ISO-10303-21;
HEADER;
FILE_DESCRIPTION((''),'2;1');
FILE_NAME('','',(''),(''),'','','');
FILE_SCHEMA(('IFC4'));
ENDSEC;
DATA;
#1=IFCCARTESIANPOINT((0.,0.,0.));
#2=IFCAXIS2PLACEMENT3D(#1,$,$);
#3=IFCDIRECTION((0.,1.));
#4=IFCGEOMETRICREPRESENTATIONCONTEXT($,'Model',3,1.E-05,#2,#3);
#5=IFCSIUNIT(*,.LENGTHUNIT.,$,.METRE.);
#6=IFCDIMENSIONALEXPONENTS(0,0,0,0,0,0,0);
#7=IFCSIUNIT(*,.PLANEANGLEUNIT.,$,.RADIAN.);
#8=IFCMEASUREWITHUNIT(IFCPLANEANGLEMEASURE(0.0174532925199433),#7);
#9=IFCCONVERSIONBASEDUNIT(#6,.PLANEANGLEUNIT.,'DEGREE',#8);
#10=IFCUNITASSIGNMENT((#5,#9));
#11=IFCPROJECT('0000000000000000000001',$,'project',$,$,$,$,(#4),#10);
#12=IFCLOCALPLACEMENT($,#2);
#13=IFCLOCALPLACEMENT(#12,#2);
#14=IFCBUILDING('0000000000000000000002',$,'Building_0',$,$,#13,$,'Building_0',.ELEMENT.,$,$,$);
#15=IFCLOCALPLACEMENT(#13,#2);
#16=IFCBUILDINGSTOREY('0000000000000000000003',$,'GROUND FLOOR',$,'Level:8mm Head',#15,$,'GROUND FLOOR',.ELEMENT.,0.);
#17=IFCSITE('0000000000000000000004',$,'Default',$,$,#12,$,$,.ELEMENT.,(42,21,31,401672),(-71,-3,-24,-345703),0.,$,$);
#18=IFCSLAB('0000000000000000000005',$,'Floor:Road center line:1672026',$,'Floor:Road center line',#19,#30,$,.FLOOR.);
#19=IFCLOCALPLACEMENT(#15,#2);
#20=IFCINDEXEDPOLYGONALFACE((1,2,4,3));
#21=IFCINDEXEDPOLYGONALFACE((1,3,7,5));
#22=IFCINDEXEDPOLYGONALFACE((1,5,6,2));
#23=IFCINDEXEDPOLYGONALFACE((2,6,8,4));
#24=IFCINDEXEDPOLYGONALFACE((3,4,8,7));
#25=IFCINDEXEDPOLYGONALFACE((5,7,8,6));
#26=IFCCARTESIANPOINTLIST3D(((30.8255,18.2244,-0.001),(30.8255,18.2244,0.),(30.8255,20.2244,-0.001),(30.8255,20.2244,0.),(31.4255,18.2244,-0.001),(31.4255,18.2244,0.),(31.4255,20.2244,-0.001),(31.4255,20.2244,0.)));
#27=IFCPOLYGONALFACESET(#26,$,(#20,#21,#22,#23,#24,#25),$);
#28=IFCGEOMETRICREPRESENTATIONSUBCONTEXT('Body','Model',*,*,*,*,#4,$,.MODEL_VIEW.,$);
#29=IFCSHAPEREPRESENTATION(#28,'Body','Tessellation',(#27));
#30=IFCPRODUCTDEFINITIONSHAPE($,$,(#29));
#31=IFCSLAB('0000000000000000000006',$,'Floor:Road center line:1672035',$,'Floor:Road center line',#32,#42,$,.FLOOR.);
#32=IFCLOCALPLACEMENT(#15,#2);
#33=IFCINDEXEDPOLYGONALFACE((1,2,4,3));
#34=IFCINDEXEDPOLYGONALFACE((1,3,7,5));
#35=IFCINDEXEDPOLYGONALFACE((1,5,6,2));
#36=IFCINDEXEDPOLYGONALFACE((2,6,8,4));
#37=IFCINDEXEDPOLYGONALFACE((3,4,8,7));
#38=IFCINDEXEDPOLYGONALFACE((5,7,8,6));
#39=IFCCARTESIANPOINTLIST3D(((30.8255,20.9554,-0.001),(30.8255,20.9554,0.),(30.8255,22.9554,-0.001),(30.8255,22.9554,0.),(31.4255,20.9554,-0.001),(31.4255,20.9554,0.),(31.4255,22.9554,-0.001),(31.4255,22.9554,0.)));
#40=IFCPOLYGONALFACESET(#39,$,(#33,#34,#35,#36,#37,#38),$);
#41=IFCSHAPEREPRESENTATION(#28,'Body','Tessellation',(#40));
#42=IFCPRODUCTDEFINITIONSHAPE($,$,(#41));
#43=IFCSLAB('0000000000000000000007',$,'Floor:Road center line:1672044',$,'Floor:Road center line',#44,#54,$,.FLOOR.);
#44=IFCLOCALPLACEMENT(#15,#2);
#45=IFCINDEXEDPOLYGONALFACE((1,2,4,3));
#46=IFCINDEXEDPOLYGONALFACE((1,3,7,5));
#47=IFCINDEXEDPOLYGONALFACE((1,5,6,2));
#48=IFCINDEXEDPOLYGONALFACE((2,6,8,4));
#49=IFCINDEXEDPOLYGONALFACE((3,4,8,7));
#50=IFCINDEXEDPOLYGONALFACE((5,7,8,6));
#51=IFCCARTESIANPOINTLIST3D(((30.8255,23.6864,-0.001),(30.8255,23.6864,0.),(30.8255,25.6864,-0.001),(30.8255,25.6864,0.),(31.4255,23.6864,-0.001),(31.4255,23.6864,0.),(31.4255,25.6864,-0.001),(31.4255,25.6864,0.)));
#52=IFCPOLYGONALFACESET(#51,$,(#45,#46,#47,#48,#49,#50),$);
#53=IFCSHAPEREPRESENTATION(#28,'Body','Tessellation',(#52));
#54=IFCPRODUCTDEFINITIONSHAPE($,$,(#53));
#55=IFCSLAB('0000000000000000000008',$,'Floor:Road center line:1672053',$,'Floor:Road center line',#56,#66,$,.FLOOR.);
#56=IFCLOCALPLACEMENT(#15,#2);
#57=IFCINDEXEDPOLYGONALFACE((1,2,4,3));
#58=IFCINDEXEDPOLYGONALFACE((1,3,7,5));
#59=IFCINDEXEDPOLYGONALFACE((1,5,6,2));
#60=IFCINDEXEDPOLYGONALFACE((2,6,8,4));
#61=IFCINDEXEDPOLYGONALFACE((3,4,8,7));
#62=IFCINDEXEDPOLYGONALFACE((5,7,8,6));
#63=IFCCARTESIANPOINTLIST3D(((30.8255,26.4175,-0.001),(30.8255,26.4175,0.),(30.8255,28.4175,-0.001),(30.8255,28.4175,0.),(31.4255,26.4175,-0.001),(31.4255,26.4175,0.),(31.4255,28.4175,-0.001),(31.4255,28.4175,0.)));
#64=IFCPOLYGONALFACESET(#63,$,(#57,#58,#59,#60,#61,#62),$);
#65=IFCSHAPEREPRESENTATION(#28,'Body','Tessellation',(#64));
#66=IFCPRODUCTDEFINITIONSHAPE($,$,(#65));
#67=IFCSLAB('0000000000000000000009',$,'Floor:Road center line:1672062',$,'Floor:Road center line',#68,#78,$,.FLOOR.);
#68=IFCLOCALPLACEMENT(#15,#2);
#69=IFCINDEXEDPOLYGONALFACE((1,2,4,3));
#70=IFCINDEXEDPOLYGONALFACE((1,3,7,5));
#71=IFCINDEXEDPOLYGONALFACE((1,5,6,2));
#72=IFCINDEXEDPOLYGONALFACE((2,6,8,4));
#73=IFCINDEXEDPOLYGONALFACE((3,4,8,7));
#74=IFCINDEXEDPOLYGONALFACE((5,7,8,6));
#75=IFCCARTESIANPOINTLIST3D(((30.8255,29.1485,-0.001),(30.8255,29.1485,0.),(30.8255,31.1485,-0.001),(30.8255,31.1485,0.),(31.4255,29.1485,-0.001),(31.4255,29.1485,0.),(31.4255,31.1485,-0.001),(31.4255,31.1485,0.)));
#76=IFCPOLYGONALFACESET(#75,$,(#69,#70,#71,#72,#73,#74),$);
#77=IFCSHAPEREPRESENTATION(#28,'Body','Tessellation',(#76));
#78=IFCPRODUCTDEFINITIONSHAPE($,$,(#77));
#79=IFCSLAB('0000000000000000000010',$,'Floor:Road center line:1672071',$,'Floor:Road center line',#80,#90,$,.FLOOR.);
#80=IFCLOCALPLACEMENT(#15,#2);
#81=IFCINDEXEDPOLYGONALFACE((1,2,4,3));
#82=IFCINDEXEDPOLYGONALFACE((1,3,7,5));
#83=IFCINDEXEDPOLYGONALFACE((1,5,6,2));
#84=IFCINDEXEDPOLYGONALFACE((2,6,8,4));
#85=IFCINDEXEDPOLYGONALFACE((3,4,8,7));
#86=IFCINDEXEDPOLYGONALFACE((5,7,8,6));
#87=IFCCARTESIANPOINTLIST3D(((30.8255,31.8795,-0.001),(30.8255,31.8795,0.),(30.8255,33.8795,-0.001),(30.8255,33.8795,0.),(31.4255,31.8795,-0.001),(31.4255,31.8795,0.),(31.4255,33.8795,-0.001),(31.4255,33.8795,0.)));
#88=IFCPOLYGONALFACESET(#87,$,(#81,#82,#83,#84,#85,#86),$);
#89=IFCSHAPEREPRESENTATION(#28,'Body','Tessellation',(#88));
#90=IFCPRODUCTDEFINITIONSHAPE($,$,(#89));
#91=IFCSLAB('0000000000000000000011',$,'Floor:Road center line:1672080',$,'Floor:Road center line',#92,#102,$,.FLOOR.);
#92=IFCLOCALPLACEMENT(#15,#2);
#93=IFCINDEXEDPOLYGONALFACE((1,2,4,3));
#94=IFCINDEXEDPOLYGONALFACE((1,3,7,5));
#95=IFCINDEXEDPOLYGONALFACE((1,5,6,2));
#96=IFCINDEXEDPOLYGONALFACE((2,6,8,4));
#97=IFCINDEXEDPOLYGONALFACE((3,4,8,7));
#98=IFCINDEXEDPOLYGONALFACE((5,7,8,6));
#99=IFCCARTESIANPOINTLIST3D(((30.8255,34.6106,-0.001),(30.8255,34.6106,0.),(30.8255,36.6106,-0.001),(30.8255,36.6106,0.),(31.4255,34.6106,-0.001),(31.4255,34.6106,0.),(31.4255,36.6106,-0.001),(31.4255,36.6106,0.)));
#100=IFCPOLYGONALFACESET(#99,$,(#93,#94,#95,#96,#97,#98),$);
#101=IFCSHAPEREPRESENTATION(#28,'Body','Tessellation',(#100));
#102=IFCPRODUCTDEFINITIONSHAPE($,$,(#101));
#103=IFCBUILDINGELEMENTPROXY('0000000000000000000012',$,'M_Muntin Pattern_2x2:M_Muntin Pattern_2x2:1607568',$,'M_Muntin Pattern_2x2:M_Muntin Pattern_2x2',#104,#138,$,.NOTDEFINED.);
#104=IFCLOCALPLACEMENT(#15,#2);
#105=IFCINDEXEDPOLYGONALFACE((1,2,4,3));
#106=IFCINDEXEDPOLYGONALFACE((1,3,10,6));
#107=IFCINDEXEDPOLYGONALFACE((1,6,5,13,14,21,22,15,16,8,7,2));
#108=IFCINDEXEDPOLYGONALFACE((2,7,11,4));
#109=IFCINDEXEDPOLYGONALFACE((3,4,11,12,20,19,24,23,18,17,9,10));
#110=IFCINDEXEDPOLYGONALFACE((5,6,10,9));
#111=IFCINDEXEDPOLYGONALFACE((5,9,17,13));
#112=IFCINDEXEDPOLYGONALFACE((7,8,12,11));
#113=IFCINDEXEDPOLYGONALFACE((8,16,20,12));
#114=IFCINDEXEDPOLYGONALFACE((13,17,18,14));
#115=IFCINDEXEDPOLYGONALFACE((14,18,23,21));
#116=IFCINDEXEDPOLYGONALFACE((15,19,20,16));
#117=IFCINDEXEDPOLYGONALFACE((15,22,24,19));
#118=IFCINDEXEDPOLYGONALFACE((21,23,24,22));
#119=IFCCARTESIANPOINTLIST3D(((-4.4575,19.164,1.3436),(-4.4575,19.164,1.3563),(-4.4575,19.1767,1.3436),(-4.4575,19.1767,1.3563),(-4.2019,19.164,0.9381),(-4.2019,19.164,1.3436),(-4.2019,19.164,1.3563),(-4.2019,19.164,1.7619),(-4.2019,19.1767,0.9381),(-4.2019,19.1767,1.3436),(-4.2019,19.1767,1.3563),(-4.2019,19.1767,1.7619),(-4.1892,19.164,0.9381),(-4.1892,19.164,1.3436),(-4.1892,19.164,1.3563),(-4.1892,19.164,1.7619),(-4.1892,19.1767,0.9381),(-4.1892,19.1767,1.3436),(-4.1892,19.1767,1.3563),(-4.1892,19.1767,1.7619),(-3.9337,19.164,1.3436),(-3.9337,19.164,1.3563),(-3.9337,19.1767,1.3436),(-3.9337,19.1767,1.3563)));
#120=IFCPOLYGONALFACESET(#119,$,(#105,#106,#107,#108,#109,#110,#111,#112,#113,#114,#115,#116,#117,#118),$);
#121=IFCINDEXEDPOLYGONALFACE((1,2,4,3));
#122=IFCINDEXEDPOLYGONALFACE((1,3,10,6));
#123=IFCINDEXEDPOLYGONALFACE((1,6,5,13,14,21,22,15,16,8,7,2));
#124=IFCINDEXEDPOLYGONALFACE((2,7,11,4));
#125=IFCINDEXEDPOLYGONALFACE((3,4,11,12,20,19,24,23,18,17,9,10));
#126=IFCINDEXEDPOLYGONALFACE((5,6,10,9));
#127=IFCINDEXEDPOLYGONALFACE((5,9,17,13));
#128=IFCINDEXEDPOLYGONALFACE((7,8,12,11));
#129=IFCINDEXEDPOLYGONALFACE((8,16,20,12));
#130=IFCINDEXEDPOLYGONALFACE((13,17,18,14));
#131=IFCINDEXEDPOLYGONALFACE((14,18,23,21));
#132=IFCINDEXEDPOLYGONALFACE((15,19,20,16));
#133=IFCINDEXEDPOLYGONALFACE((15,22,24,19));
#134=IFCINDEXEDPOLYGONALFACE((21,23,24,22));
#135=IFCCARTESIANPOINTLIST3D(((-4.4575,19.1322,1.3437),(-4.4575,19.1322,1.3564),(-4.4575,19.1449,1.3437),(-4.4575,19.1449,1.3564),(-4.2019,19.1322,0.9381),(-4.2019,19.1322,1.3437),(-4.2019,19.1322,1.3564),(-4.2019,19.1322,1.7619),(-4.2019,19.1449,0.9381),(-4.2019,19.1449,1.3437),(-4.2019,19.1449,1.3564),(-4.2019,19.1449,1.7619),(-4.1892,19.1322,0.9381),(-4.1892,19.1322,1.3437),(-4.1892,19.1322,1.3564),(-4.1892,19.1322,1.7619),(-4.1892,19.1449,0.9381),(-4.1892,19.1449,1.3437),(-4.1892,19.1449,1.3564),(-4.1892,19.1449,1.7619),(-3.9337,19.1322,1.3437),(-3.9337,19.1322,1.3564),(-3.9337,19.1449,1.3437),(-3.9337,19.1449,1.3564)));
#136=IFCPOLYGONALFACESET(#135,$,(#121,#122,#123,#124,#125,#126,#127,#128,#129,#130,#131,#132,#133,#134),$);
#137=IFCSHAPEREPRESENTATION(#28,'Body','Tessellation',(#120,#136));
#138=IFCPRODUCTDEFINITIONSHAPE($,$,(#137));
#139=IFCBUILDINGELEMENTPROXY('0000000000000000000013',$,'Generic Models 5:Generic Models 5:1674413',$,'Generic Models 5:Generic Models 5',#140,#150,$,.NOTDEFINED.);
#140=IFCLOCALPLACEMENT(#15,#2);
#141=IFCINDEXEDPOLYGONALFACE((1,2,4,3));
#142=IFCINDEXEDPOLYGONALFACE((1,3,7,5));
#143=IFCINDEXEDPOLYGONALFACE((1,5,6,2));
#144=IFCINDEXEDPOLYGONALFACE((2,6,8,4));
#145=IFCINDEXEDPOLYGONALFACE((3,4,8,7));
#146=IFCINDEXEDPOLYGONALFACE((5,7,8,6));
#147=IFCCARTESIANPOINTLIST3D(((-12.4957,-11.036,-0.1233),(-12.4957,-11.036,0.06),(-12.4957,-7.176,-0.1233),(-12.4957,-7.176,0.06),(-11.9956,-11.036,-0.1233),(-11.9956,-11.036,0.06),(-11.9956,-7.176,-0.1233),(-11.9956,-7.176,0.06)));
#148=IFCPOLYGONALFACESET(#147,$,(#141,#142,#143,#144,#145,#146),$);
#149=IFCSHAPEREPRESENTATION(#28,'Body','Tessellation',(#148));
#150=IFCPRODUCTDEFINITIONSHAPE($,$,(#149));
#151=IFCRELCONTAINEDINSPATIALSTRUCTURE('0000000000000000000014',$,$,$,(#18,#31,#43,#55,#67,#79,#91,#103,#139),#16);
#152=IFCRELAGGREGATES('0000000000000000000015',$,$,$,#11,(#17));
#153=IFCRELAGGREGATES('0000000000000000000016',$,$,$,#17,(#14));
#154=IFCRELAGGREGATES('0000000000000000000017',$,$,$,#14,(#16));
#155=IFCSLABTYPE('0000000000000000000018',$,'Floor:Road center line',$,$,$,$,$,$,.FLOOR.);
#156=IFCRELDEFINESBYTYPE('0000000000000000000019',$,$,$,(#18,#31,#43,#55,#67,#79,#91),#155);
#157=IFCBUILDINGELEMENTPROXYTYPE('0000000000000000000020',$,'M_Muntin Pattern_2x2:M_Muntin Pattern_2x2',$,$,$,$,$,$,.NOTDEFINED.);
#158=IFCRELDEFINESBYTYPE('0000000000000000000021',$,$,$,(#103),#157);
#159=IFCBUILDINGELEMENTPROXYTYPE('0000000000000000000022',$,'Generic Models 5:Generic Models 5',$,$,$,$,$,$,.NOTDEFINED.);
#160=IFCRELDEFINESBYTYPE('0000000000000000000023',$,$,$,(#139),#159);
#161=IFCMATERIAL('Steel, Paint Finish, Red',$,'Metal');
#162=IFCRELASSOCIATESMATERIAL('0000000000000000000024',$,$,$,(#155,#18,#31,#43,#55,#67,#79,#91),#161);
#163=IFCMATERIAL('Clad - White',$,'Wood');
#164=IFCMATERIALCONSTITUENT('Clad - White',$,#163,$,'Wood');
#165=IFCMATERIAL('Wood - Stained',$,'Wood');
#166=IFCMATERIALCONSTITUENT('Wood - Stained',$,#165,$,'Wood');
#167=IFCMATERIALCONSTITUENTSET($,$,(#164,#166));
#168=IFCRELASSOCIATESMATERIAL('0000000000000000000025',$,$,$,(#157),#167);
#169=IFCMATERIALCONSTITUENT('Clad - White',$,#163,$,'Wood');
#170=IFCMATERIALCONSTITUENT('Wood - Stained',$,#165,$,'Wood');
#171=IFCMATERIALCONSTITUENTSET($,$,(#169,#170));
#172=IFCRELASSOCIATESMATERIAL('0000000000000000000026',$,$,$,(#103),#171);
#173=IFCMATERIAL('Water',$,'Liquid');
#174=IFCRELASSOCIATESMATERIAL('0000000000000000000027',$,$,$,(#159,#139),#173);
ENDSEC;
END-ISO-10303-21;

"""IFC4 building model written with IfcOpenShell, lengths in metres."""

from ifc_helpers import new_model, entity, si_unit, converted_unit, direction, frame, origin, place, context, subcontext, project, spatial, indexed_curve, outline, extrude, source, transform, mapped, material, constituent, constituent_set, type_object, type_shapes, element, save


model = new_model("IFC4")

# Units and contexts
model_context = context("Model", 3, precision=1e-05, world=origin(), true_north=direction((0.0, 1.0)))
body_context = subcontext(model_context, "Body", "Model", "MODEL_VIEW")
ifc_project = project(units=[si_unit("LENGTHUNIT", "METRE"), converted_unit("PLANEANGLEUNIT", "DEGREE", entity("IfcPlaneAngleMeasure", 0.0174532925199433), si_unit("PLANEANGLEUNIT", "RADIAN"), dimensions=[0, 0, 0, 0, 0, 0, 0])], contexts=[model_context])

# Site, building, storey
site_placement = place(None, origin())
site = spatial("IfcSite", under=ifc_project, at=site_placement, Name="Default", CompositionType="ELEMENT", RefLatitude=(42, 21, 31, 401672), RefLongitude=(-71, -3, -24, -345703), RefElevation=0.0)
building_placement = place(site_placement, origin())
building = spatial("IfcBuilding", under=site, at=building_placement, Name="Building_0", LongName="Building_0", CompositionType="ELEMENT")
storey_placement = place(building_placement, origin())
storey = spatial("IfcBuildingStorey", under=building, at=storey_placement, Name="GROUND FLOOR", ObjectType="Level:8mm Head", LongName="GROUND FLOOR", CompositionType="ELEMENT", Elevation=0.0)

# Slabs
ifc_material_1 = material(Name="Steel, Paint Finish, Red", Category="Metal")
slab_type = type_object("IfcSlabType", Name="Floor:Road center line", PredefinedType="FLOOR", material=ifc_material_1)
slab_1_placement = place(storey_placement, origin())
element("IfcSlab", 1, at=slab_1_placement, inside=storey, type_object=slab_type, material=ifc_material_1, Name="Floor:Road center line:1672026", ObjectType="Floor:Road center line", PredefinedType="FLOOR", context=body_context, shape_type="SweptSolid", body=[
    extrude(outline(indexed_curve([(-1.0, -0.3), (1.0, -0.3), (1.0, 0.3), (-1.0, 0.3), (-1.0, -0.3)], self_intersect=False)), frame((31.1255, 19.2244, 0.0), z_axis=(0.0, 0.0, -1.0), x_axis=(0.0, 1.0, 0.0)), (0.0, 0.0, 1.0), 0.001),
])
slab_2_placement = place(storey_placement, origin())
element("IfcSlab", 2, at=slab_2_placement, inside=storey, type_object=slab_type, material=ifc_material_1, Name="Floor:Road center line:1672035", ObjectType="Floor:Road center line", PredefinedType="FLOOR", context=body_context, shape_type="SweptSolid", body=[
    extrude(outline(indexed_curve([(-1.0, -0.3), (1.0, -0.3), (1.0, 0.3), (-1.0, 0.3), (-1.0, -0.3)], self_intersect=False)), frame((31.1255, 21.9554, 0.0), z_axis=(0.0, 0.0, -1.0), x_axis=(0.0, 1.0, 0.0)), (0.0, 0.0, 1.0), 0.001),
])
slab_3_placement = place(storey_placement, origin())
element("IfcSlab", 3, at=slab_3_placement, inside=storey, type_object=slab_type, material=ifc_material_1, Name="Floor:Road center line:1672044", ObjectType="Floor:Road center line", PredefinedType="FLOOR", context=body_context, shape_type="SweptSolid", body=[
    extrude(outline(indexed_curve([(-1.0, -0.3), (1.0, -0.3), (1.0, 0.3), (-1.0, 0.3), (-1.0, -0.3)], self_intersect=False)), frame((31.1255, 24.6864, 0.0), z_axis=(0.0, 0.0, -1.0), x_axis=(0.0, 1.0, 0.0)), (0.0, 0.0, 1.0), 0.001),
])
slab_4_placement = place(storey_placement, origin())
element("IfcSlab", 4, at=slab_4_placement, inside=storey, type_object=slab_type, material=ifc_material_1, Name="Floor:Road center line:1672053", ObjectType="Floor:Road center line", PredefinedType="FLOOR", context=body_context, shape_type="SweptSolid", body=[
    extrude(outline(indexed_curve([(-1.0, -0.3), (1.0, -0.3), (1.0, 0.3), (-1.0, 0.3), (-1.0, -0.3)], self_intersect=False)), frame((31.1255, 27.4175, 0.0), z_axis=(0.0, 0.0, -1.0), x_axis=(0.0, 1.0, 0.0)), (0.0, 0.0, 1.0), 0.001),
])
slab_5_placement = place(storey_placement, origin())
element("IfcSlab", 5, at=slab_5_placement, inside=storey, type_object=slab_type, material=ifc_material_1, Name="Floor:Road center line:1672062", ObjectType="Floor:Road center line", PredefinedType="FLOOR", context=body_context, shape_type="SweptSolid", body=[
    extrude(outline(indexed_curve([(-1.0, -0.3), (1.0, -0.3), (1.0, 0.3), (-1.0, 0.3), (-1.0, -0.3)], self_intersect=False)), frame((31.1255, 30.1485, 0.0), z_axis=(0.0, 0.0, -1.0), x_axis=(0.0, 1.0, 0.0)), (0.0, 0.0, 1.0), 0.001),
])
slab_6_placement = place(storey_placement, origin())
element("IfcSlab", 6, at=slab_6_placement, inside=storey, type_object=slab_type, material=ifc_material_1, Name="Floor:Road center line:1672071", ObjectType="Floor:Road center line", PredefinedType="FLOOR", context=body_context, shape_type="SweptSolid", body=[
    extrude(outline(indexed_curve([(-1.0, -0.3), (1.0, -0.3), (1.0, 0.3), (-1.0, 0.3), (-1.0, -0.3)], self_intersect=False)), frame((31.1255, 32.8795, 0.0), z_axis=(0.0, 0.0, -1.0), x_axis=(0.0, 1.0, 0.0)), (0.0, 0.0, 1.0), 0.001),
])
slab_7_placement = place(storey_placement, origin())
element("IfcSlab", 7, at=slab_7_placement, inside=storey, type_object=slab_type, material=ifc_material_1, Name="Floor:Road center line:1672080", ObjectType="Floor:Road center line", PredefinedType="FLOOR", context=body_context, shape_type="SweptSolid", body=[
    extrude(outline(indexed_curve([(-1.0, -0.3), (1.0, -0.3), (1.0, 0.3), (-1.0, 0.3), (-1.0, -0.3)], self_intersect=False)), frame((31.1255, 35.6106, 0.0), z_axis=(0.0, 0.0, -1.0), x_axis=(0.0, 1.0, 0.0)), (0.0, 0.0, 1.0), 0.001),
])

# Shared definitions
ifc_material_2 = material(Name="Clad - White", Category="Wood")

# Building element proxies
ifc_constituent_1 = constituent(ifc_material_2, Name="Clad - White", Category="Wood")
ifc_material_3 = material(Name="Wood - Stained", Category="Wood")
ifc_constituent_2 = constituent(ifc_material_3, Name="Wood - Stained", Category="Wood")
ifc_constituent_set_1 = constituent_set(constituents=[ifc_constituent_1, ifc_constituent_2])
ifc_constituent_3 = constituent(ifc_material_2, Name="Clad - White", Category="Wood")
ifc_constituent_4 = constituent(ifc_material_3, Name="Wood - Stained", Category="Wood")
ifc_constituent_set_2 = constituent_set(constituents=[ifc_constituent_3, ifc_constituent_4])
building_element_proxy_type_1 = type_object("IfcBuildingElementProxyType", Name="M_Muntin Pattern_2x2:M_Muntin Pattern_2x2", PredefinedType="NOTDEFINED", material=ifc_constituent_set_2)
shared_shape_1 = source(origin(), body_context, "Body", "SweptSolid", [
    extrude(outline(indexed_curve([(0.0064, -0.0064), (0.4119, -0.0064), (0.4119, 0.0063), (0.0064, 0.0063), (0.0064, 0.2619), (-0.0063, 0.2619), (-0.0063, 0.0063), (-0.4119, 0.0063), (-0.4119, -0.0064), (-0.0063, -0.0064), (-0.0063, -0.2619), (0.0064, -0.2619), (0.0064, -0.0064)], self_intersect=False)), frame((0.0, 0.0095, 0.4119), z_axis=(0.0, 1.0, 0.0), x_axis=(0.0, 0.0, 1.0)), (0.0, 0.0, 1.0), 0.0127),
    extrude(outline(indexed_curve([(0.0064, -0.0064), (0.4119, -0.0064), (0.4119, 0.0063), (0.0064, 0.0063), (0.0064, 0.2619), (-0.0063, 0.2619), (-0.0063, 0.0063), (-0.4119, 0.0063), (-0.4119, -0.0064), (-0.0063, -0.0064), (-0.0063, -0.2619), (0.0064, -0.2619), (0.0064, -0.0064)], self_intersect=False)), frame((0.0, -0.0222, 0.4119), z_axis=(0.0, 1.0, 0.0), x_axis=(0.0, 0.0, 1.0)), (0.0, 0.0, 1.0), 0.0127),
])
type_shapes(building_element_proxy_type_1, [shared_shape_1])
proxy_1_placement = place(storey_placement, frame((-4.1956, 19.1545, 0.9381)))
element("IfcBuildingElementProxy", 8, at=proxy_1_placement, inside=storey, type_object=building_element_proxy_type_1, material=ifc_constituent_set_1, Name="M_Muntin Pattern_2x2:M_Muntin Pattern_2x2:1607568", ObjectType="M_Muntin Pattern_2x2:M_Muntin Pattern_2x2", PredefinedType="NOTDEFINED", context=body_context, shape_type="MappedRepresentation", body=[
    mapped(shared_shape_1, transform((0.0, 0.0, 0.0), scale=1.0)),
])
ifc_material_4 = material(Name="Water", Category="Liquid")
building_element_proxy_type_2 = type_object("IfcBuildingElementProxyType", Name="Generic Models 5:Generic Models 5", PredefinedType="NOTDEFINED", material=ifc_material_4)
shared_shape_2 = source(origin(), body_context, "Body", "SweptSolid", [
    extrude(outline(indexed_curve([(-1.93, -0.25), (1.93, -0.25), (1.93, 0.25), (-1.93, 0.25), (-1.93, -0.25)], self_intersect=False)), frame((-12.2456, -9.106, -0.1233), z_axis=(0.0, 0.0, 1.0), x_axis=(0.0, -1.0, 0.0)), (0.0, 0.0, 1.0), 0.1833),
])
type_shapes(building_element_proxy_type_2, [shared_shape_2])
proxy_2_placement = place(storey_placement, origin())
element("IfcBuildingElementProxy", 9, at=proxy_2_placement, inside=storey, type_object=building_element_proxy_type_2, material=ifc_material_4, Name="Generic Models 5:Generic Models 5:1674413", ObjectType="Generic Models 5:Generic Models 5", PredefinedType="NOTDEFINED", context=body_context, shape_type="MappedRepresentation", body=[
    mapped(shared_shape_2, transform((0.0, 0.0, 0.0), scale=1.0)),
])

save(model, "model.ifc")
